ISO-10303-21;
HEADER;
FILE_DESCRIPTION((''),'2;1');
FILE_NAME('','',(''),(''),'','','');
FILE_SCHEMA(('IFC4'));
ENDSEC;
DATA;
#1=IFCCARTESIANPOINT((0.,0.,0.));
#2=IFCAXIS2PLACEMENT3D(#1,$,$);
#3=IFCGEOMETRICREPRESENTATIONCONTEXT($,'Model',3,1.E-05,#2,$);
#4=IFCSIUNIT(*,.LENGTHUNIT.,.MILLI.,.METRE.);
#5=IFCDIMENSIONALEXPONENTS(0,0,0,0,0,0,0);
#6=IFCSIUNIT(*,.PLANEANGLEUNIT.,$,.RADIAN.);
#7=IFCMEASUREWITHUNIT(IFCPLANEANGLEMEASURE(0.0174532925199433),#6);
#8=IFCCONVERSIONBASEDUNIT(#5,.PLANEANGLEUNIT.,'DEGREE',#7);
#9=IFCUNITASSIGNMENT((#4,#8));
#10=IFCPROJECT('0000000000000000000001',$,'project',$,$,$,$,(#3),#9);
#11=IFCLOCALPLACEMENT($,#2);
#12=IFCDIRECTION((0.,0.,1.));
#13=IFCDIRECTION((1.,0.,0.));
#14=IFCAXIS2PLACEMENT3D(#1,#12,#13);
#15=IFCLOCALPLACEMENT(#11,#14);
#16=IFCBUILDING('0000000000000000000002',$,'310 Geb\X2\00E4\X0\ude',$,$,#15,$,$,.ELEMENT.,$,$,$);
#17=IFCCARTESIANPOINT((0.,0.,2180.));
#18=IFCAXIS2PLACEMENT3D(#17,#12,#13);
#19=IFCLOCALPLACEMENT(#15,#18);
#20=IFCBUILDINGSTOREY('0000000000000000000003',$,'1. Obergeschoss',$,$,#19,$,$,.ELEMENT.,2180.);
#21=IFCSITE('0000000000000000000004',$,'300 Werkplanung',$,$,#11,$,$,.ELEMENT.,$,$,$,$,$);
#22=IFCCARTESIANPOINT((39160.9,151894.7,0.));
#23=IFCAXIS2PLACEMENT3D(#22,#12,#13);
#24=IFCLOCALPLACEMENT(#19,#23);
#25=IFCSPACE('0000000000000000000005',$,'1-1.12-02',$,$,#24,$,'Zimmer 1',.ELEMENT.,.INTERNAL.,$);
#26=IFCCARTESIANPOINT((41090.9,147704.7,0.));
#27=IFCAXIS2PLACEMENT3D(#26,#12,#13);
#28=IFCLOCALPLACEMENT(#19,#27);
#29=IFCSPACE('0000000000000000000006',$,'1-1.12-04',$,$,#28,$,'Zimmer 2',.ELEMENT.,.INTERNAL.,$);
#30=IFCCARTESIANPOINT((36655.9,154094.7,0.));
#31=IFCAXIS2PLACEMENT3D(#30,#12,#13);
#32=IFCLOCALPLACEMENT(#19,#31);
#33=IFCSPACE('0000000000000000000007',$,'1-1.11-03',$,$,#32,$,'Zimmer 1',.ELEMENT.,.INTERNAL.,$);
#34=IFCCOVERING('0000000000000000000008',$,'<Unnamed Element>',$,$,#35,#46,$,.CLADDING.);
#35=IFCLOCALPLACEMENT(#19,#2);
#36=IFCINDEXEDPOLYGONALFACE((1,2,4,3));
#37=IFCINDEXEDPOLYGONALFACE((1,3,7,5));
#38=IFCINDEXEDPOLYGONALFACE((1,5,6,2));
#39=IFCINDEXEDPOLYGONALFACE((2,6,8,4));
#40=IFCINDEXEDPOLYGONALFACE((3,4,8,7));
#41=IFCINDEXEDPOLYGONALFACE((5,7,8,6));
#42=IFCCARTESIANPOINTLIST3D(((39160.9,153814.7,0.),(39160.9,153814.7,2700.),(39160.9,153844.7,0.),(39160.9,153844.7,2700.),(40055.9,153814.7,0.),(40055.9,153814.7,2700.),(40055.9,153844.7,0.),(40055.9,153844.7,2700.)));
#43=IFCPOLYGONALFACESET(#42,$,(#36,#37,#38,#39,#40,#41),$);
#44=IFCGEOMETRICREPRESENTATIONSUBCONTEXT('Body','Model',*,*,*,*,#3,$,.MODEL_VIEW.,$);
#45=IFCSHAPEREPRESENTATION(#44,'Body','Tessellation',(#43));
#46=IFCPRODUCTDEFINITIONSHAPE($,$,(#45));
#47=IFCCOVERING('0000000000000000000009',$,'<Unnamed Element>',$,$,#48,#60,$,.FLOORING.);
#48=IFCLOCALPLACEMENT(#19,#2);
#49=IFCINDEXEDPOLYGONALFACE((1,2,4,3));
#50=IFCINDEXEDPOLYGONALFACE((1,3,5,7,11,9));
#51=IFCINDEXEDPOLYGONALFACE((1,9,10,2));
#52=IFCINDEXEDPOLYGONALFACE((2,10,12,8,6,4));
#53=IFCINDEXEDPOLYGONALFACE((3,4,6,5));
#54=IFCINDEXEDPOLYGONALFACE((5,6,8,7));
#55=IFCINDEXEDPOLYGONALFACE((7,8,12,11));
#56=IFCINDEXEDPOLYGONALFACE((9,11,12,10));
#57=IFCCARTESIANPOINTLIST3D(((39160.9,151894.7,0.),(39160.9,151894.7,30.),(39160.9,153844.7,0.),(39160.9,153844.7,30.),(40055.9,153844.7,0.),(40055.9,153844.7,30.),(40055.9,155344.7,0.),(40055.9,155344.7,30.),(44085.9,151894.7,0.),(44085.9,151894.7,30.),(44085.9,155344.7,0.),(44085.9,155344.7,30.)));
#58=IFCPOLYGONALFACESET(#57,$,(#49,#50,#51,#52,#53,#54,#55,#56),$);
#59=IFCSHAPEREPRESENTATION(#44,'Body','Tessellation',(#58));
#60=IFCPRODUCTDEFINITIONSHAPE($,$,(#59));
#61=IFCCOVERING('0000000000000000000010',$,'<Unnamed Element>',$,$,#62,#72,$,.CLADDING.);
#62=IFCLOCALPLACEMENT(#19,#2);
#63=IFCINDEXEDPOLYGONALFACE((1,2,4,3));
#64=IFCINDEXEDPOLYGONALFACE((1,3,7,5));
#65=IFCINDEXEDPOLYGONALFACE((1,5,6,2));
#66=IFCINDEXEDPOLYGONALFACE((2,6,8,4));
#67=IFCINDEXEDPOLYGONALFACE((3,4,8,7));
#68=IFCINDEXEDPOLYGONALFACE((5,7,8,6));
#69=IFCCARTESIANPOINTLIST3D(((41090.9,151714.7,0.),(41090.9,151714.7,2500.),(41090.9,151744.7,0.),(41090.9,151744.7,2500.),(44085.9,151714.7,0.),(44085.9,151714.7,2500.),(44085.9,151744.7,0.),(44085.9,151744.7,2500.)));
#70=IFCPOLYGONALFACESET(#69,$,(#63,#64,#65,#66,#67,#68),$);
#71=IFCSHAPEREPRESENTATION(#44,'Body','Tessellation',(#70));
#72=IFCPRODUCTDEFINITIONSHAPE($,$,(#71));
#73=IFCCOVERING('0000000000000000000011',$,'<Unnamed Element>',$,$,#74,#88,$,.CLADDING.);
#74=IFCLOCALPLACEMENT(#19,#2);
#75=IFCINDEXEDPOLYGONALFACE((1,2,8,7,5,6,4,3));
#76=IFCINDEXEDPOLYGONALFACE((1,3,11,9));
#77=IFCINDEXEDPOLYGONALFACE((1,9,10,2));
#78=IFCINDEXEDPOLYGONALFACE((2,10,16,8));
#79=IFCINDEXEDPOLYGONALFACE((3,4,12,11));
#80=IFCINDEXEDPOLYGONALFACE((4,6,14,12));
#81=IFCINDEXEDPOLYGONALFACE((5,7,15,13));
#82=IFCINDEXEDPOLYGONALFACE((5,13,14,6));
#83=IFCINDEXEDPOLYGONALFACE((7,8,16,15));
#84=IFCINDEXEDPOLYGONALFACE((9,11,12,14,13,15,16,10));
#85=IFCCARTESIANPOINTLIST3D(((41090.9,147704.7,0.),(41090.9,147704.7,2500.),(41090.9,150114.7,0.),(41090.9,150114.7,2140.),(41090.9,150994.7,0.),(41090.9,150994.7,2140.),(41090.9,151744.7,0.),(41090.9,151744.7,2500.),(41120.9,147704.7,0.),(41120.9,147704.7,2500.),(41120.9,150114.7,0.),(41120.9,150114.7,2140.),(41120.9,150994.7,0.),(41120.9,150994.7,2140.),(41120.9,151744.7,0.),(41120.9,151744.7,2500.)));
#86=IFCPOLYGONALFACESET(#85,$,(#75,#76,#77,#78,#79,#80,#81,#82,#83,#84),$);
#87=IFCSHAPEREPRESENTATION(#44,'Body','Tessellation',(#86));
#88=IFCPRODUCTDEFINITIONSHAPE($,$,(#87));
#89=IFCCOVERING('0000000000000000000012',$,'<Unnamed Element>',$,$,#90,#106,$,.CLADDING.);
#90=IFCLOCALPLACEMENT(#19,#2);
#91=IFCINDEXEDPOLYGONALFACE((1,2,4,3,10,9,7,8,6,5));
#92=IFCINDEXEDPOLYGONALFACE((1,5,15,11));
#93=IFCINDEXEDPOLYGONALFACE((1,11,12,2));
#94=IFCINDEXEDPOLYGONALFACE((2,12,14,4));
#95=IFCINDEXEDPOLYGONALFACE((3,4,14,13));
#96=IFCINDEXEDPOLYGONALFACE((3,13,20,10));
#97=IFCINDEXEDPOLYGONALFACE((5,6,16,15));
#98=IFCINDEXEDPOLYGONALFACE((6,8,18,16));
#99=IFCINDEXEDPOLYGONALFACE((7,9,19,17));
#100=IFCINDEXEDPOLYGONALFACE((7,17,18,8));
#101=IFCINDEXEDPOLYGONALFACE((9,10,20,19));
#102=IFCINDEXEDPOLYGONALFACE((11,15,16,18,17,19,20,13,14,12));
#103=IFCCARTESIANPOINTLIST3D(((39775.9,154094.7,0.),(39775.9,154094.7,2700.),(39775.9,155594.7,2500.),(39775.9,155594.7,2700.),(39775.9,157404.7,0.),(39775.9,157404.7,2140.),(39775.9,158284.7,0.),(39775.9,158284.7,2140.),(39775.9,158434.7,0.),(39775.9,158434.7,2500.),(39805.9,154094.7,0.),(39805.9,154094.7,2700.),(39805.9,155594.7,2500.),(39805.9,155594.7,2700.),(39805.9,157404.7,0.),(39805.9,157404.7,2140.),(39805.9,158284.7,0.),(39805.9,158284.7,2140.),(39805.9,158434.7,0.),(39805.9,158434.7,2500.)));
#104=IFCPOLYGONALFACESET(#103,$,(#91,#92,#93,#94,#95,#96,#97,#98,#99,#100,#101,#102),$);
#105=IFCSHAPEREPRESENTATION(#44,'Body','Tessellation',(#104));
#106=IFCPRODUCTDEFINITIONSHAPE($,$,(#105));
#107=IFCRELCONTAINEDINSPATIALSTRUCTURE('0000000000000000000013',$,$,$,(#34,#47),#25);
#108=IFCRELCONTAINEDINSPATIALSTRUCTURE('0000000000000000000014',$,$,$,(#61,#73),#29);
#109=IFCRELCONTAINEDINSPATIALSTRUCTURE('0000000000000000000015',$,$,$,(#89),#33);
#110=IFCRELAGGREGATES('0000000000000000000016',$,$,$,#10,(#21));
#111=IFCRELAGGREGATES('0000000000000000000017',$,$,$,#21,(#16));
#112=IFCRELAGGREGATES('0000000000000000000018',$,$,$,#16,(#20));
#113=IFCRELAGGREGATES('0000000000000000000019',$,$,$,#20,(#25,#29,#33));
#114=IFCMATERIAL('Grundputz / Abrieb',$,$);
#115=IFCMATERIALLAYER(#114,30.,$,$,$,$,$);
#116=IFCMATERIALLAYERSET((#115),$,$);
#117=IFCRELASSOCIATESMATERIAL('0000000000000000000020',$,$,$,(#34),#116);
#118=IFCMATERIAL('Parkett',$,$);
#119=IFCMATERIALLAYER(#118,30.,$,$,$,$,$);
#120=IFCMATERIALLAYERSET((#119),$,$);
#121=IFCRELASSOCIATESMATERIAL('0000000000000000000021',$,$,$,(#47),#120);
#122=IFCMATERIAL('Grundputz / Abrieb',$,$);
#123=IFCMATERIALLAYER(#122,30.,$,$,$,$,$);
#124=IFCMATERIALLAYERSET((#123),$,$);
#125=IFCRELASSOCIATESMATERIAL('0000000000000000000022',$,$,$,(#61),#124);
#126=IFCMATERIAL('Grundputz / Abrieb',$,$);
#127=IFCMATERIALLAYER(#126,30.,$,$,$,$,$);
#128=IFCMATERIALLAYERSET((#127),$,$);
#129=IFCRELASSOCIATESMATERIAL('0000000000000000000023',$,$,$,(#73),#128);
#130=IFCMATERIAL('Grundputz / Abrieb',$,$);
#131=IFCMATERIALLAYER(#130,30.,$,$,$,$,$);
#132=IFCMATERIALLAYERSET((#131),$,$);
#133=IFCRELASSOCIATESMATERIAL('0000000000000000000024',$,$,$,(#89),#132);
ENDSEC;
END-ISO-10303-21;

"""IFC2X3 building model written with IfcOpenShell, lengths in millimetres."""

from ifc_helpers import new_model, entity, si_unit, converted_unit, frame, frame_2d, origin, origin_with_axes, place, context, subcontext, project, spatial, polyline, rectangle, outline, extrude, material, layer, layer_set, layer_usage, element, save


model = new_model("IFC2X3")

# Units and contexts
model_context = context("Model", 3, precision=1e-05, world=origin())
body_context = subcontext(model_context, "Body", "Model", "MODEL_VIEW")
ifc_project = project(units=[si_unit("LENGTHUNIT", "METRE", prefix="MILLI"), converted_unit("PLANEANGLEUNIT", "DEGREE", entity("IfcPlaneAngleMeasure", 0.0174532925199433), si_unit("PLANEANGLEUNIT", "RADIAN"), dimensions=[0, 0, 0, 0, 0, 0, 0])], contexts=[model_context])

# Site, building, storey
site_placement = place(None, origin())
site = spatial("IfcSite", under=ifc_project, at=site_placement, Name="300 Werkplanung", CompositionType="ELEMENT")
building_placement = place(site_placement, origin_with_axes())
building = spatial("IfcBuilding", under=site, at=building_placement, Name="310 Gebäude", CompositionType="ELEMENT")
storey_placement = place(building_placement, frame((0.0, 0.0, 2180.0), z_axis=(0.0, 0.0, 1.0), x_axis=(1.0, 0.0, 0.0)))
storey = spatial("IfcBuildingStorey", under=building, at=storey_placement, Name="1. Obergeschoss", CompositionType="ELEMENT", Elevation=2180.0)

# Shared definitions
space_1_placement = place(storey_placement, frame((39160.9, 151894.7, 0.0), z_axis=(0.0, 0.0, 1.0), x_axis=(1.0, 0.0, 0.0)))
space_1 = spatial("IfcSpace", under=storey, at=space_1_placement, Name="1-1.12-02", LongName="Zimmer 1", CompositionType="ELEMENT", InteriorOrExteriorSpace="INTERNAL")

# Coverings
ifc_material_1 = material(Name="Grundputz / Abrieb")
ifc_layer_1 = layer(ifc_material_1, 30.0)
ifc_layer_set_1 = layer_set([ifc_layer_1])
ifc_layer_usage_1 = layer_usage(ifc_layer_set_1, "AXIS3", "POSITIVE", 0.0)
covering_1_placement = place(space_1_placement, frame((895.0, 1950.0, 0.0), z_axis=(0.0, 0.0, 1.0), x_axis=(-1.0, 0.0, 0.0)))
element("IfcCovering", 1, at=covering_1_placement, inside=space_1, material=ifc_layer_usage_1, Name="<Unnamed Element>", PredefinedType="CLADDING", context=body_context, shape_type="SweptSolid", body=[
    extrude(rectangle(XDim=2700.0, YDim=895.0, at=frame_2d((-447.5, 1350.0), x_axis=(0.0, 1.0))), frame((895.0, 0.0, 2700.0), z_axis=(0.0, 1.0, 0.0), x_axis=(1.0, 0.0, 0.0)), (0.0, 0.0, 1.0), 30.0),
])
ifc_material_2 = material(Name="Parkett")
ifc_layer_2 = layer(ifc_material_2, 30.0)
ifc_layer_set_2 = layer_set([ifc_layer_2])
ifc_layer_usage_2 = layer_usage(ifc_layer_set_2, "AXIS3", "POSITIVE", 0.0)
covering_2_placement = place(space_1_placement, origin_with_axes())
element("IfcCovering", 2, at=covering_2_placement, inside=space_1, material=ifc_layer_usage_2, Name="<Unnamed Element>", PredefinedType="FLOORING", context=body_context, shape_type="SweptSolid", body=[
    extrude(outline(polyline([(4925.0, 0.0), (4925.0, 3450.0), (895.0, 3450.0), (895.0, 1950.0), (0.0, 1950.0), (0.0, 0.0), (4925.0, 0.0)])), origin_with_axes(), (0.0, 0.0, 1.0), 30.0),
])

# Shared definitions
space_2_placement = place(storey_placement, frame((41090.9, 147704.7, 0.0), z_axis=(0.0, 0.0, 1.0), x_axis=(1.0, 0.0, 0.0)))
space_2 = spatial("IfcSpace", under=storey, at=space_2_placement, Name="1-1.12-04", LongName="Zimmer 2", CompositionType="ELEMENT", InteriorOrExteriorSpace="INTERNAL")

# Coverings
ifc_material_3 = material(Name="Grundputz / Abrieb")
ifc_layer_3 = layer(ifc_material_3, 30.0)
ifc_layer_set_3 = layer_set([ifc_layer_3])
ifc_layer_usage_3 = layer_usage(ifc_layer_set_3, "AXIS3", "POSITIVE", 0.0)
covering_3_placement = place(space_2_placement, frame((2995.0, 4040.0, 0.0), z_axis=(0.0, 0.0, 1.0), x_axis=(-1.0, 0.0, 0.0)))
element("IfcCovering", 3, at=covering_3_placement, inside=space_2, material=ifc_layer_usage_3, Name="<Unnamed Element>", PredefinedType="CLADDING", context=body_context, shape_type="SweptSolid", body=[
    extrude(rectangle(XDim=2500.0, YDim=2995.0, at=frame_2d((-1497.5, 1250.0), x_axis=(0.0, 1.0))), frame((2995.0, 0.0, 2500.0), z_axis=(0.0, 1.0, 0.0), x_axis=(1.0, 0.0, 0.0)), (0.0, 0.0, 1.0), 30.0),
])
ifc_material_4 = material(Name="Grundputz / Abrieb")
ifc_layer_4 = layer(ifc_material_4, 30.0)
ifc_layer_set_4 = layer_set([ifc_layer_4])
ifc_layer_usage_4 = layer_usage(ifc_layer_set_4, "AXIS3", "POSITIVE", 0.0)
covering_4_placement = place(space_2_placement, frame((0.0, 4040.0, 0.0), z_axis=(0.0, 0.0, 1.0), x_axis=(0.0, -1.0, 0.0)))
element("IfcCovering", 4, at=covering_4_placement, inside=space_2, material=ifc_layer_usage_4, Name="<Unnamed Element>", PredefinedType="CLADDING", context=body_context, shape_type="SweptSolid", body=[
    extrude(outline(polyline([(4040.0, 0.0), (4040.0, -2500.0), (0.0, -2500.0), (0.0, 0.0), (750.0, 0.0), (750.0, -2140.0), (1630.0, -2140.0), (1630.0, 0.0), (4040.0, 0.0)])), frame((0.0, 0.0, 0.0), z_axis=(0.0, 1.0, 0.0), x_axis=(1.0, 0.0, 0.0)), (0.0, 0.0, 1.0), 30.0),
])

# Shared definitions
space_3_placement = place(storey_placement, frame((36655.9, 154094.7, 0.0), z_axis=(0.0, 0.0, 1.0), x_axis=(1.0, 0.0, 0.0)))
space_3 = spatial("IfcSpace", under=storey, at=space_3_placement, Name="1-1.11-03", LongName="Zimmer 1", CompositionType="ELEMENT", InteriorOrExteriorSpace="INTERNAL")

# Covering
ifc_material_5 = material(Name="Grundputz / Abrieb")
ifc_layer_5 = layer(ifc_material_5, 30.0)
ifc_layer_set_5 = layer_set([ifc_layer_5])
ifc_layer_usage_5 = layer_usage(ifc_layer_set_5, "AXIS3", "POSITIVE", 0.0)
covering_5_placement = place(space_3_placement, frame((3150.0, 0.0, 0.0), z_axis=(0.0, 0.0, 1.0), x_axis=(0.0, 1.0, 0.0)))
element("IfcCovering", 5, at=covering_5_placement, inside=space_3, material=ifc_layer_usage_5, Name="<Unnamed Element>", PredefinedType="CLADDING", context=body_context, shape_type="SweptSolid", body=[
    extrude(outline(polyline([(4340.0, 0.0), (4340.0, -2500.0), (1500.0, -2500.0), (1500.0, -2700.0), (0.0, -2700.0), (0.0, 0.0), (3310.0, 0.0), (3310.0, -2140.0), (4190.0, -2140.0), (4190.0, 0.0), (4340.0, 0.0)])), frame((0.0, 0.0, 0.0), z_axis=(0.0, 1.0, 0.0), x_axis=(1.0, 0.0, 0.0)), (0.0, 0.0, 1.0), 30.0),
])

save(model, "model.ifc")
